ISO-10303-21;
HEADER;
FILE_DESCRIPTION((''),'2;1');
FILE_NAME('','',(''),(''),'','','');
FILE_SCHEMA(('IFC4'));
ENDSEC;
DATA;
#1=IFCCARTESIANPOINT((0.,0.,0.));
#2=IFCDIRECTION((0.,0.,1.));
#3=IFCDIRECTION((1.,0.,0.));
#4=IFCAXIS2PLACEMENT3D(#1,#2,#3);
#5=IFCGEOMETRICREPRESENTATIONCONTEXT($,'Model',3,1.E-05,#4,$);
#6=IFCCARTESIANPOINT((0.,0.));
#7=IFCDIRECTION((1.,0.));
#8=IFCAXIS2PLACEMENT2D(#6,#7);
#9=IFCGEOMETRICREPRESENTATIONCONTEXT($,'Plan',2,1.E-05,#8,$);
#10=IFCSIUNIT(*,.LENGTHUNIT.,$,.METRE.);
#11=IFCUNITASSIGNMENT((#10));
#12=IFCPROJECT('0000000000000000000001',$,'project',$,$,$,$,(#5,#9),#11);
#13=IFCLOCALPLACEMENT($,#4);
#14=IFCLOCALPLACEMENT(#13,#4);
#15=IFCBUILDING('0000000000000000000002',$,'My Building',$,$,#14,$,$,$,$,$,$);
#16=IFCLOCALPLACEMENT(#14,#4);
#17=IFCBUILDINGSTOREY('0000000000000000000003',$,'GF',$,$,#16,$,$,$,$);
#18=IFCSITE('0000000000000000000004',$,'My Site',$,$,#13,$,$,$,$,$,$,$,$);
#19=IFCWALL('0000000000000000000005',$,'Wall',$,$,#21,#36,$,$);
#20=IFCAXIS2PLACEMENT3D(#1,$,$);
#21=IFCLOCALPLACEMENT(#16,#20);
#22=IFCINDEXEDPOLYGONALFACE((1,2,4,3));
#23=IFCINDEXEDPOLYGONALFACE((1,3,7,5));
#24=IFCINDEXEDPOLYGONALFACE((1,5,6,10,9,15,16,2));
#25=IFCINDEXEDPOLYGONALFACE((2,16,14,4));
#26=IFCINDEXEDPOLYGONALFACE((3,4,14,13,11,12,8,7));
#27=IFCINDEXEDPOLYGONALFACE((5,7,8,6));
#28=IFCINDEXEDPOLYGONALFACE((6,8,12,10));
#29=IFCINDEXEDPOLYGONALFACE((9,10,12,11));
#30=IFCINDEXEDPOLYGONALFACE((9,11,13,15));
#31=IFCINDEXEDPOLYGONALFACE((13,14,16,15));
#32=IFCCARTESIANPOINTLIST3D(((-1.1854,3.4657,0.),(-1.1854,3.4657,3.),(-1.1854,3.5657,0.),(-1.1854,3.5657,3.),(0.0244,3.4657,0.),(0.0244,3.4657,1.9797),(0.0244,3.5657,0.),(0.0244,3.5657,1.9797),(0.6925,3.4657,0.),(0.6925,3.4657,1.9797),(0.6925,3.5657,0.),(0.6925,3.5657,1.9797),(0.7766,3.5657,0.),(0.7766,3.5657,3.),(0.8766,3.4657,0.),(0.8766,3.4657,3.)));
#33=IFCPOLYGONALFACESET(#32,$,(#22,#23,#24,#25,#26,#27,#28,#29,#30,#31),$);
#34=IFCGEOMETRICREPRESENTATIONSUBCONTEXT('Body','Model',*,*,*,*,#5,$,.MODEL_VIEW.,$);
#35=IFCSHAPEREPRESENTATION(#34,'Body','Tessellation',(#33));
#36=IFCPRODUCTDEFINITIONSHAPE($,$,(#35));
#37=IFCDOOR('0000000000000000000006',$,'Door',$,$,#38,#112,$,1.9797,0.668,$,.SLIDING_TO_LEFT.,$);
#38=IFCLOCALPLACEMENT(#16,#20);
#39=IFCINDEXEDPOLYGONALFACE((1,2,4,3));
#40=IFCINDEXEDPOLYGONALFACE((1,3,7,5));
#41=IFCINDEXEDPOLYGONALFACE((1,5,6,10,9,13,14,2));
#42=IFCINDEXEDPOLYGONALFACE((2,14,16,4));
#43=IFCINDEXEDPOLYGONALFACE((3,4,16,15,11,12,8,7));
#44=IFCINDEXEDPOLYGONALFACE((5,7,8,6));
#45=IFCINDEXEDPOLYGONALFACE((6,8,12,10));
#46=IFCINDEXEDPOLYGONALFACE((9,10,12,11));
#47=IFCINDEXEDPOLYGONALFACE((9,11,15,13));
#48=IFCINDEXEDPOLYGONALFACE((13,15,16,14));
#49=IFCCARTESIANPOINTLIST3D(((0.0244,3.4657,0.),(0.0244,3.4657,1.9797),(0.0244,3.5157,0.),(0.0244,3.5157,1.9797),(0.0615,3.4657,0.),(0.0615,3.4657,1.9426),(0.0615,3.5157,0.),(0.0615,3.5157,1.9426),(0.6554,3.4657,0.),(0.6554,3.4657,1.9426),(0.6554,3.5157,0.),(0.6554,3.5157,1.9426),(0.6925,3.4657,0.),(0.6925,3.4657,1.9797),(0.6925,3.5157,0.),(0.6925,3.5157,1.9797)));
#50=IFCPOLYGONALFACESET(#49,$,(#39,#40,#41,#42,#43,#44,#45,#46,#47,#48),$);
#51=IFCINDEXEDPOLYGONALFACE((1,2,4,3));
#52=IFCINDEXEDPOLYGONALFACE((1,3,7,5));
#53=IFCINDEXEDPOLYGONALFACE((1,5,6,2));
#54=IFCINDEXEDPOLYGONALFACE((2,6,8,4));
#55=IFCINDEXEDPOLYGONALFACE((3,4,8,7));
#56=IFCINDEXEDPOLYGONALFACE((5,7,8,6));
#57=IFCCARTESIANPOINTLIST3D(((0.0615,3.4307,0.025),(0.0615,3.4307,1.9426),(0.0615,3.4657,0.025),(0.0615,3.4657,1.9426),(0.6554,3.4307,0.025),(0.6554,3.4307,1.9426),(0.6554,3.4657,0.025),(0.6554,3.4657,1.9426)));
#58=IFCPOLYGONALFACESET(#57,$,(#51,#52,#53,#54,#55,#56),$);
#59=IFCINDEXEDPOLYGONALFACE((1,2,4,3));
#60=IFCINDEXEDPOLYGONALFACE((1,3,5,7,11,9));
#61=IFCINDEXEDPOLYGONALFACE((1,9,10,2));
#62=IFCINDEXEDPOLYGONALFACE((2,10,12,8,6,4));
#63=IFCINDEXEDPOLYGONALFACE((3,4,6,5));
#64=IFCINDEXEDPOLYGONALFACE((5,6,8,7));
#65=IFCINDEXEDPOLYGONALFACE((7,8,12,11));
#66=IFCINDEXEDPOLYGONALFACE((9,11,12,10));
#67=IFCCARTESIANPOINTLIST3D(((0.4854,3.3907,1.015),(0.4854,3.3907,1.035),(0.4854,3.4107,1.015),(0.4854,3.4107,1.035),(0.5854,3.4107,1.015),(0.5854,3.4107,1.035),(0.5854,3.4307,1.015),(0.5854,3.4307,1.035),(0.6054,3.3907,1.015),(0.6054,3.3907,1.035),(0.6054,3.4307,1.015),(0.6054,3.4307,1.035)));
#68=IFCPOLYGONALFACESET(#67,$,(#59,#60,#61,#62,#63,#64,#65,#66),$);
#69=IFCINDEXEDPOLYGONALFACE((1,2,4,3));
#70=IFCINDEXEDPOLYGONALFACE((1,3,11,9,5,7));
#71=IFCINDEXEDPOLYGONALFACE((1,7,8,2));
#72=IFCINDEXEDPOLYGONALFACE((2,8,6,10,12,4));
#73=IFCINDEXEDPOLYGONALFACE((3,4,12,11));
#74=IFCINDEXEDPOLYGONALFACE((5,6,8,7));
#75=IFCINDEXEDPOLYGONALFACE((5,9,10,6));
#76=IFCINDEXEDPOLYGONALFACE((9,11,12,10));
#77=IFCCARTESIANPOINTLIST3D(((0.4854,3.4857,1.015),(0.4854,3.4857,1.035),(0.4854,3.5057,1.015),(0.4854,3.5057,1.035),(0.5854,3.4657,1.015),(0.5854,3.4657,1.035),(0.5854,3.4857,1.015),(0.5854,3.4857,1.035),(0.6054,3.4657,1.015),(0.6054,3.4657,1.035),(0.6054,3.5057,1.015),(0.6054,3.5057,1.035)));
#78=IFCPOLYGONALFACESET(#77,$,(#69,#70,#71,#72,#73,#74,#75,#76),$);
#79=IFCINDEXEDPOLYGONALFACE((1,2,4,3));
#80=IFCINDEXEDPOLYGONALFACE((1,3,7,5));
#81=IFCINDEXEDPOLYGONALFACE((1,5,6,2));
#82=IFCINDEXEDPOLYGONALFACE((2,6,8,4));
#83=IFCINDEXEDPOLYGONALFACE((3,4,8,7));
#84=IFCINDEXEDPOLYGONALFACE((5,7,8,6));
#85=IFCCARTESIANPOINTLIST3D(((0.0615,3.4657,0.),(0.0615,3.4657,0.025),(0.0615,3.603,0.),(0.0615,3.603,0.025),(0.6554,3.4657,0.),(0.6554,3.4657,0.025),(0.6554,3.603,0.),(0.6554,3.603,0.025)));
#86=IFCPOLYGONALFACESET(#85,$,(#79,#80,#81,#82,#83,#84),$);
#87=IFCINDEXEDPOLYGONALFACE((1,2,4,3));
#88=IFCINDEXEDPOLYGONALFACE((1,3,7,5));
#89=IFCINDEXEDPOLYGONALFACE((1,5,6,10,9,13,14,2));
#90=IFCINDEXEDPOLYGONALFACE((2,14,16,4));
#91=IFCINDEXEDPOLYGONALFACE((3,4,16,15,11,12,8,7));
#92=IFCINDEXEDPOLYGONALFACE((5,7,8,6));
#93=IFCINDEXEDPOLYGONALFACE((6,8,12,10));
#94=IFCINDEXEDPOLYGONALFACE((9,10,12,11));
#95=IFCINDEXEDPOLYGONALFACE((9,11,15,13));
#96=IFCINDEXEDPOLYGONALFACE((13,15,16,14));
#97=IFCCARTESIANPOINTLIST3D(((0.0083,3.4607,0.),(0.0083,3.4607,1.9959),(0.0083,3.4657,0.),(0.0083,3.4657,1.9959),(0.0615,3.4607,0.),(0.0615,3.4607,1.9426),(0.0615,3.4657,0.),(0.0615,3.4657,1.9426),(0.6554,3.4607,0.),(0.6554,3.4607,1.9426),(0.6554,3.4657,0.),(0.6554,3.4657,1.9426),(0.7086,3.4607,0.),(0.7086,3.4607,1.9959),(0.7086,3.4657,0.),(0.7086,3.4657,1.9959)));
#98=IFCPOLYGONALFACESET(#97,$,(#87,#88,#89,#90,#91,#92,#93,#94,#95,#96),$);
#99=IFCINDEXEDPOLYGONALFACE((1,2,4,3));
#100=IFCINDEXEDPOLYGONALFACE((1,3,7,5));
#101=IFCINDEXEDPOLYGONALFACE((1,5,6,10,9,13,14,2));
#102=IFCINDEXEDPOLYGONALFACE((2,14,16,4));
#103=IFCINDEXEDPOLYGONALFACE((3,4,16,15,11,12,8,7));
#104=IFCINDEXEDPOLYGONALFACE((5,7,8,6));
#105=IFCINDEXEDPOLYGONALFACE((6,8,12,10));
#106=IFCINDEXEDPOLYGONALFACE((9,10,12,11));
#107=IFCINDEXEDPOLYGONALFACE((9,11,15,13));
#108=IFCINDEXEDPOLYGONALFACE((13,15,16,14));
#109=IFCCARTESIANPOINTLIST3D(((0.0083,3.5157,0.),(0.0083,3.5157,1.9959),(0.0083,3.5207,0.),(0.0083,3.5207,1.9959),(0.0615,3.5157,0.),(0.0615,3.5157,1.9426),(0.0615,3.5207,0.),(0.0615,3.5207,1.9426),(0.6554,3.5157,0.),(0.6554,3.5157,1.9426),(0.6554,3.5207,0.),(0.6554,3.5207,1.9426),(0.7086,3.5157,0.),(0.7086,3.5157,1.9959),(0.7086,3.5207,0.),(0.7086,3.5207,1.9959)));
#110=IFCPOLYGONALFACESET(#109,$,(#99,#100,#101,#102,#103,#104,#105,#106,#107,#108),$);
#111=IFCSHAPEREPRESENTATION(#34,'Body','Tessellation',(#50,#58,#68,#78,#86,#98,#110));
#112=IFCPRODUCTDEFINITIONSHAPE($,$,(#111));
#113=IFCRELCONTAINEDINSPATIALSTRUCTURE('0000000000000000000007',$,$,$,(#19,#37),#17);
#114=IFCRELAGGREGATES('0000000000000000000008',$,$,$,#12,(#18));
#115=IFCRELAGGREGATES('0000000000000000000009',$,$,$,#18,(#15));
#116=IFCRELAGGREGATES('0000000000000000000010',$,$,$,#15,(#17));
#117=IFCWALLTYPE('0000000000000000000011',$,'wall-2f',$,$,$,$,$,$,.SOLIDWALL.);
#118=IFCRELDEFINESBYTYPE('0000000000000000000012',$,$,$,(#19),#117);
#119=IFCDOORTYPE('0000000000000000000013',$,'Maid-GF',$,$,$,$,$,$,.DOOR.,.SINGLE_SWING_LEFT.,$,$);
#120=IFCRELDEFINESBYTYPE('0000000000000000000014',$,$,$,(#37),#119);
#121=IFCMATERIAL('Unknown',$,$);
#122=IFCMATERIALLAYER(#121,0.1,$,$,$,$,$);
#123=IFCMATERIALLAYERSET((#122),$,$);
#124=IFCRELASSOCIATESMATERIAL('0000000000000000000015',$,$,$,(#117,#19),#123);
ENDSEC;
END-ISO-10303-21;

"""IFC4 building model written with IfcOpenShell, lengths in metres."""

from ifc_helpers import new_model, entity, si_unit, frame, origin_with_axes, origin_2d_with_axis, place, context, subcontext, project, spatial, line, indexed_curve, outline, extrude, shape, source, transform, mapped, material, layer, layer_set, layer_usage, type_object, type_shapes, element, fill, save


model = new_model("IFC4")

# Units and contexts
model_context = context("Model", 3, precision=1e-05, world=origin_with_axes())
plan_context = context("Plan", 2, precision=1e-05, world=origin_2d_with_axis())
body_context_1 = subcontext(model_context, "Body", "Model", "MODEL_VIEW")
body_context_2 = subcontext(plan_context, "Body", "Plan", "PLAN_VIEW")
ifc_project = project(units=[si_unit("LENGTHUNIT", "METRE")], contexts=[model_context, plan_context])

# Site, building, storey
site_placement = place(None, origin_with_axes())
site = spatial("IfcSite", under=ifc_project, at=site_placement, Name="My Site")
building_placement = place(site_placement, origin_with_axes())
building = spatial("IfcBuilding", under=site, at=building_placement, Name="My Building")
storey_placement = place(building_placement, origin_with_axes())
storey = spatial("IfcBuildingStorey", under=building, at=storey_placement, Name="GF")

# Shared definitions
ifc_material = material(Name="Unknown")

# Shared definitions
ifc_layer_1 = layer(ifc_material, 0.1)
ifc_layer_set_1 = layer_set([ifc_layer_1])
wall_type = type_object("IfcWallType", Name="wall-2f", PredefinedType="SOLIDWALL", material=ifc_layer_set_1)

# Wall, opening, door
ifc_layer_usage_1 = layer_usage(ifc_layer_set_1, "AXIS2", "POSITIVE", 0.0)
wall_1_placement = place(storey_placement, frame((0.7766, 3.5657, 0.0), z_axis=(0.0, 0.0, 1.0), x_axis=(-1.0, 0.0, 0.0)))
wall_1 = element("IfcWall", 1, at=wall_1_placement, inside=storey, type_object=wall_type, material=ifc_layer_usage_1, Name="Wall", context=body_context_1, shape_type="SweptSolid", body=[
    extrude(outline(indexed_curve([(0.0, 0.0), (-0.1, 0.1), (1.962, 0.1), (1.962, 0.0)], segments=[line(1, 2, 3, 4, 1)])), origin_with_axes(), (0.0, 0.0, 1.0), 3.0),
])
shared_shape_1 = source(origin_with_axes(), body_context_1, "Body", "SweptSolid", [
    extrude(outline(indexed_curve([(0.0, 0.0), (0.668, 0.0), (0.668, 1.9797), (0.0, 1.9797)], segments=[line(1, 2, 3, 4, 1)])), frame((0.0, -0.6, 0.0), z_axis=(0.0, -1.0, 0.0), x_axis=(1.0, 0.0, 0.0)), (0.0, 0.0, -1.0), 1.2),
])
opening_1_placement = place(wall_1_placement, frame((0.7522, 0.1, 0.0), z_axis=(0.0, 0.0, 1.0), x_axis=(-1.0, 0.0, 0.0)))
opening_1 = element("IfcOpeningElement", 2, at=opening_1_placement, cuts=wall_1, PredefinedType="OPENING", context=body_context_1, shape_type="MappedRepresentation", body=[
    mapped(shared_shape_1, transform((0.0, 0.0, 0.0), x_axis=(1.0, 0.0, 0.0), y_axis=(0.0, 1.0, 0.0), z_axis=(0.0, 0.0, 1.0), scale=1.0)),
])
door_type_1 = type_object("IfcDoorType", Name="Maid-GF", OperationType="SINGLE_SWING_LEFT", PredefinedType="DOOR")
shared_shape_2 = source(origin_with_axes(), body_context_1, "Body", "SweptSolid", [
    extrude(outline(indexed_curve([(0.0, 0.0), (0.0, 1.9797), (0.668, 1.9797), (0.668, 0.0), (0.6309, 0.0), (0.6309, 1.9426), (0.0371, 1.9426), (0.0371, 0.0)], segments=[line(1, 2, 3, 4, 5, 6, 7, 8, 1)])), frame((0.0, 0.0, 0.0), z_axis=(0.0, -1.0, 0.0), x_axis=(1.0, 0.0, 0.0)), (0.0, 0.0, -1.0), 0.05),
    extrude(outline(indexed_curve([(0.0, 0.0), (0.5938, 0.0), (0.5938, 0.035), (0.0, 0.035)], segments=[line(1, 2, 3, 4, 1)])), frame((0.0371, -0.035, 0.025), z_axis=(0.0, 0.0, 1.0), x_axis=(1.0, 0.0, 0.0)), (0.0, 0.0, 1.0), 1.9176),
    extrude(outline(indexed_curve([(0.0, 0.0), (0.0, -0.04), (-0.12, -0.04), (-0.12, -0.02), (-0.02, -0.02), (-0.02, 0.0)], segments=[line(1, 2, 3, 4, 5, 6, 1)])), frame((0.5809, -0.035, 1.015), z_axis=(0.0, 0.0, 1.0), x_axis=(1.0, 0.0, 0.0)), (0.0, 0.0, 1.0), 0.02),
    extrude(outline(indexed_curve([(0.0, 0.0), (0.0, 0.04), (-0.12, 0.04), (-0.12, 0.02), (-0.02, 0.02), (-0.02, 0.0)], segments=[line(1, 2, 3, 4, 5, 6, 1)])), frame((0.5809, 0.0, 1.015), z_axis=(0.0, 0.0, 1.0), x_axis=(1.0, 0.0, 0.0)), (0.0, 0.0, 1.0), 0.02),
    extrude(outline(indexed_curve([(0.0, 0.0), (0.5938, 0.0), (0.5938, 0.1372), (0.0, 0.1372)], segments=[line(1, 2, 3, 4, 1)])), frame((0.0371, 0.0, 0.0), z_axis=(0.0, 0.0, 1.0), x_axis=(1.0, 0.0, 0.0)), (0.0, 0.0, 1.0), 0.025),
    extrude(outline(indexed_curve([(0.0, 0.0), (0.0, 1.9959), (0.7003, 1.9959), (0.7003, 0.0), (0.6471, 0.0), (0.6471, 1.9426), (0.0532, 1.9426), (0.0532, 0.0)], segments=[line(1, 2, 3, 4, 5, 6, 7, 8, 1)])), frame((-0.0162, -0.005, 0.0), z_axis=(0.0, -1.0, 0.0), x_axis=(1.0, 0.0, 0.0)), (0.0, 0.0, -1.0), 0.005),
    extrude(outline(indexed_curve([(0.0, 0.0), (0.0, 1.9959), (0.7003, 1.9959), (0.7003, 0.0), (0.6471, 0.0), (0.6471, 1.9426), (0.0532, 1.9426), (0.0532, 0.0)], segments=[line(1, 2, 3, 4, 5, 6, 7, 8, 1)])), frame((-0.0162, 0.05, 0.0), z_axis=(0.0, -1.0, 0.0), x_axis=(1.0, 0.0, 0.0)), (0.0, 0.0, -1.0), 0.005),
])
shared_shape_3 = source(origin_with_axes(), body_context_2, "Body", "Curve2D", [
    entity("IfcIndexedPolyCurve", entity("IfcCartesianPointList2D", [[0.0, 0.0], [0.0371, 0.0], [0.0371, 0.05], [0.0, 0.05]]), [entity("IfcLineIndex", [1, 2, 3, 4, 1])]),
    entity("IfcIndexedPolyCurve", entity("IfcCartesianPointList2D", [[0.668, 0.0], [0.6309, 0.0], [0.6309, 0.05], [0.668, 0.05]]), [entity("IfcLineIndex", [1, 2, 3, 4, 1])]),
    entity("IfcIndexedPolyCurve", entity("IfcCartesianPointList2D", [[-0.2598, -0.035], [0.334, -0.035], [0.334, 0.0], [-0.2598, 0.0]]), [entity("IfcLineIndex", [1, 2, 3, 4, 1])]),
])
type_shapes(door_type_1, [shared_shape_2, shared_shape_3])
door_1_placement = place(opening_1_placement, origin_with_axes())
door_1 = element("IfcDoor", 3, at=door_1_placement, inside=storey, type_object=door_type_1, Name="Door", OperationType="SLIDING_TO_LEFT", OverallHeight=1.9797, OverallWidth=0.668, shapes=[
    shape(body_context_1, "Body", "MappedRepresentation", [mapped(shared_shape_2, transform((0.0, 0.0, 0.0), x_axis=(1.0, 0.0, 0.0), y_axis=(0.0, 1.0, 0.0), z_axis=(0.0, 0.0, 1.0), scale=1.0))]),
    shape(body_context_2, "Body", "MappedRepresentation", [mapped(shared_shape_3, transform((0.0, 0.0, 0.0), x_axis=(1.0, 0.0, 0.0), y_axis=(0.0, 1.0, 0.0), z_axis=(0.0, 0.0, 1.0), scale=1.0))]),
])
fill(opening_1, door_1)

save(model, "model.ifc")
